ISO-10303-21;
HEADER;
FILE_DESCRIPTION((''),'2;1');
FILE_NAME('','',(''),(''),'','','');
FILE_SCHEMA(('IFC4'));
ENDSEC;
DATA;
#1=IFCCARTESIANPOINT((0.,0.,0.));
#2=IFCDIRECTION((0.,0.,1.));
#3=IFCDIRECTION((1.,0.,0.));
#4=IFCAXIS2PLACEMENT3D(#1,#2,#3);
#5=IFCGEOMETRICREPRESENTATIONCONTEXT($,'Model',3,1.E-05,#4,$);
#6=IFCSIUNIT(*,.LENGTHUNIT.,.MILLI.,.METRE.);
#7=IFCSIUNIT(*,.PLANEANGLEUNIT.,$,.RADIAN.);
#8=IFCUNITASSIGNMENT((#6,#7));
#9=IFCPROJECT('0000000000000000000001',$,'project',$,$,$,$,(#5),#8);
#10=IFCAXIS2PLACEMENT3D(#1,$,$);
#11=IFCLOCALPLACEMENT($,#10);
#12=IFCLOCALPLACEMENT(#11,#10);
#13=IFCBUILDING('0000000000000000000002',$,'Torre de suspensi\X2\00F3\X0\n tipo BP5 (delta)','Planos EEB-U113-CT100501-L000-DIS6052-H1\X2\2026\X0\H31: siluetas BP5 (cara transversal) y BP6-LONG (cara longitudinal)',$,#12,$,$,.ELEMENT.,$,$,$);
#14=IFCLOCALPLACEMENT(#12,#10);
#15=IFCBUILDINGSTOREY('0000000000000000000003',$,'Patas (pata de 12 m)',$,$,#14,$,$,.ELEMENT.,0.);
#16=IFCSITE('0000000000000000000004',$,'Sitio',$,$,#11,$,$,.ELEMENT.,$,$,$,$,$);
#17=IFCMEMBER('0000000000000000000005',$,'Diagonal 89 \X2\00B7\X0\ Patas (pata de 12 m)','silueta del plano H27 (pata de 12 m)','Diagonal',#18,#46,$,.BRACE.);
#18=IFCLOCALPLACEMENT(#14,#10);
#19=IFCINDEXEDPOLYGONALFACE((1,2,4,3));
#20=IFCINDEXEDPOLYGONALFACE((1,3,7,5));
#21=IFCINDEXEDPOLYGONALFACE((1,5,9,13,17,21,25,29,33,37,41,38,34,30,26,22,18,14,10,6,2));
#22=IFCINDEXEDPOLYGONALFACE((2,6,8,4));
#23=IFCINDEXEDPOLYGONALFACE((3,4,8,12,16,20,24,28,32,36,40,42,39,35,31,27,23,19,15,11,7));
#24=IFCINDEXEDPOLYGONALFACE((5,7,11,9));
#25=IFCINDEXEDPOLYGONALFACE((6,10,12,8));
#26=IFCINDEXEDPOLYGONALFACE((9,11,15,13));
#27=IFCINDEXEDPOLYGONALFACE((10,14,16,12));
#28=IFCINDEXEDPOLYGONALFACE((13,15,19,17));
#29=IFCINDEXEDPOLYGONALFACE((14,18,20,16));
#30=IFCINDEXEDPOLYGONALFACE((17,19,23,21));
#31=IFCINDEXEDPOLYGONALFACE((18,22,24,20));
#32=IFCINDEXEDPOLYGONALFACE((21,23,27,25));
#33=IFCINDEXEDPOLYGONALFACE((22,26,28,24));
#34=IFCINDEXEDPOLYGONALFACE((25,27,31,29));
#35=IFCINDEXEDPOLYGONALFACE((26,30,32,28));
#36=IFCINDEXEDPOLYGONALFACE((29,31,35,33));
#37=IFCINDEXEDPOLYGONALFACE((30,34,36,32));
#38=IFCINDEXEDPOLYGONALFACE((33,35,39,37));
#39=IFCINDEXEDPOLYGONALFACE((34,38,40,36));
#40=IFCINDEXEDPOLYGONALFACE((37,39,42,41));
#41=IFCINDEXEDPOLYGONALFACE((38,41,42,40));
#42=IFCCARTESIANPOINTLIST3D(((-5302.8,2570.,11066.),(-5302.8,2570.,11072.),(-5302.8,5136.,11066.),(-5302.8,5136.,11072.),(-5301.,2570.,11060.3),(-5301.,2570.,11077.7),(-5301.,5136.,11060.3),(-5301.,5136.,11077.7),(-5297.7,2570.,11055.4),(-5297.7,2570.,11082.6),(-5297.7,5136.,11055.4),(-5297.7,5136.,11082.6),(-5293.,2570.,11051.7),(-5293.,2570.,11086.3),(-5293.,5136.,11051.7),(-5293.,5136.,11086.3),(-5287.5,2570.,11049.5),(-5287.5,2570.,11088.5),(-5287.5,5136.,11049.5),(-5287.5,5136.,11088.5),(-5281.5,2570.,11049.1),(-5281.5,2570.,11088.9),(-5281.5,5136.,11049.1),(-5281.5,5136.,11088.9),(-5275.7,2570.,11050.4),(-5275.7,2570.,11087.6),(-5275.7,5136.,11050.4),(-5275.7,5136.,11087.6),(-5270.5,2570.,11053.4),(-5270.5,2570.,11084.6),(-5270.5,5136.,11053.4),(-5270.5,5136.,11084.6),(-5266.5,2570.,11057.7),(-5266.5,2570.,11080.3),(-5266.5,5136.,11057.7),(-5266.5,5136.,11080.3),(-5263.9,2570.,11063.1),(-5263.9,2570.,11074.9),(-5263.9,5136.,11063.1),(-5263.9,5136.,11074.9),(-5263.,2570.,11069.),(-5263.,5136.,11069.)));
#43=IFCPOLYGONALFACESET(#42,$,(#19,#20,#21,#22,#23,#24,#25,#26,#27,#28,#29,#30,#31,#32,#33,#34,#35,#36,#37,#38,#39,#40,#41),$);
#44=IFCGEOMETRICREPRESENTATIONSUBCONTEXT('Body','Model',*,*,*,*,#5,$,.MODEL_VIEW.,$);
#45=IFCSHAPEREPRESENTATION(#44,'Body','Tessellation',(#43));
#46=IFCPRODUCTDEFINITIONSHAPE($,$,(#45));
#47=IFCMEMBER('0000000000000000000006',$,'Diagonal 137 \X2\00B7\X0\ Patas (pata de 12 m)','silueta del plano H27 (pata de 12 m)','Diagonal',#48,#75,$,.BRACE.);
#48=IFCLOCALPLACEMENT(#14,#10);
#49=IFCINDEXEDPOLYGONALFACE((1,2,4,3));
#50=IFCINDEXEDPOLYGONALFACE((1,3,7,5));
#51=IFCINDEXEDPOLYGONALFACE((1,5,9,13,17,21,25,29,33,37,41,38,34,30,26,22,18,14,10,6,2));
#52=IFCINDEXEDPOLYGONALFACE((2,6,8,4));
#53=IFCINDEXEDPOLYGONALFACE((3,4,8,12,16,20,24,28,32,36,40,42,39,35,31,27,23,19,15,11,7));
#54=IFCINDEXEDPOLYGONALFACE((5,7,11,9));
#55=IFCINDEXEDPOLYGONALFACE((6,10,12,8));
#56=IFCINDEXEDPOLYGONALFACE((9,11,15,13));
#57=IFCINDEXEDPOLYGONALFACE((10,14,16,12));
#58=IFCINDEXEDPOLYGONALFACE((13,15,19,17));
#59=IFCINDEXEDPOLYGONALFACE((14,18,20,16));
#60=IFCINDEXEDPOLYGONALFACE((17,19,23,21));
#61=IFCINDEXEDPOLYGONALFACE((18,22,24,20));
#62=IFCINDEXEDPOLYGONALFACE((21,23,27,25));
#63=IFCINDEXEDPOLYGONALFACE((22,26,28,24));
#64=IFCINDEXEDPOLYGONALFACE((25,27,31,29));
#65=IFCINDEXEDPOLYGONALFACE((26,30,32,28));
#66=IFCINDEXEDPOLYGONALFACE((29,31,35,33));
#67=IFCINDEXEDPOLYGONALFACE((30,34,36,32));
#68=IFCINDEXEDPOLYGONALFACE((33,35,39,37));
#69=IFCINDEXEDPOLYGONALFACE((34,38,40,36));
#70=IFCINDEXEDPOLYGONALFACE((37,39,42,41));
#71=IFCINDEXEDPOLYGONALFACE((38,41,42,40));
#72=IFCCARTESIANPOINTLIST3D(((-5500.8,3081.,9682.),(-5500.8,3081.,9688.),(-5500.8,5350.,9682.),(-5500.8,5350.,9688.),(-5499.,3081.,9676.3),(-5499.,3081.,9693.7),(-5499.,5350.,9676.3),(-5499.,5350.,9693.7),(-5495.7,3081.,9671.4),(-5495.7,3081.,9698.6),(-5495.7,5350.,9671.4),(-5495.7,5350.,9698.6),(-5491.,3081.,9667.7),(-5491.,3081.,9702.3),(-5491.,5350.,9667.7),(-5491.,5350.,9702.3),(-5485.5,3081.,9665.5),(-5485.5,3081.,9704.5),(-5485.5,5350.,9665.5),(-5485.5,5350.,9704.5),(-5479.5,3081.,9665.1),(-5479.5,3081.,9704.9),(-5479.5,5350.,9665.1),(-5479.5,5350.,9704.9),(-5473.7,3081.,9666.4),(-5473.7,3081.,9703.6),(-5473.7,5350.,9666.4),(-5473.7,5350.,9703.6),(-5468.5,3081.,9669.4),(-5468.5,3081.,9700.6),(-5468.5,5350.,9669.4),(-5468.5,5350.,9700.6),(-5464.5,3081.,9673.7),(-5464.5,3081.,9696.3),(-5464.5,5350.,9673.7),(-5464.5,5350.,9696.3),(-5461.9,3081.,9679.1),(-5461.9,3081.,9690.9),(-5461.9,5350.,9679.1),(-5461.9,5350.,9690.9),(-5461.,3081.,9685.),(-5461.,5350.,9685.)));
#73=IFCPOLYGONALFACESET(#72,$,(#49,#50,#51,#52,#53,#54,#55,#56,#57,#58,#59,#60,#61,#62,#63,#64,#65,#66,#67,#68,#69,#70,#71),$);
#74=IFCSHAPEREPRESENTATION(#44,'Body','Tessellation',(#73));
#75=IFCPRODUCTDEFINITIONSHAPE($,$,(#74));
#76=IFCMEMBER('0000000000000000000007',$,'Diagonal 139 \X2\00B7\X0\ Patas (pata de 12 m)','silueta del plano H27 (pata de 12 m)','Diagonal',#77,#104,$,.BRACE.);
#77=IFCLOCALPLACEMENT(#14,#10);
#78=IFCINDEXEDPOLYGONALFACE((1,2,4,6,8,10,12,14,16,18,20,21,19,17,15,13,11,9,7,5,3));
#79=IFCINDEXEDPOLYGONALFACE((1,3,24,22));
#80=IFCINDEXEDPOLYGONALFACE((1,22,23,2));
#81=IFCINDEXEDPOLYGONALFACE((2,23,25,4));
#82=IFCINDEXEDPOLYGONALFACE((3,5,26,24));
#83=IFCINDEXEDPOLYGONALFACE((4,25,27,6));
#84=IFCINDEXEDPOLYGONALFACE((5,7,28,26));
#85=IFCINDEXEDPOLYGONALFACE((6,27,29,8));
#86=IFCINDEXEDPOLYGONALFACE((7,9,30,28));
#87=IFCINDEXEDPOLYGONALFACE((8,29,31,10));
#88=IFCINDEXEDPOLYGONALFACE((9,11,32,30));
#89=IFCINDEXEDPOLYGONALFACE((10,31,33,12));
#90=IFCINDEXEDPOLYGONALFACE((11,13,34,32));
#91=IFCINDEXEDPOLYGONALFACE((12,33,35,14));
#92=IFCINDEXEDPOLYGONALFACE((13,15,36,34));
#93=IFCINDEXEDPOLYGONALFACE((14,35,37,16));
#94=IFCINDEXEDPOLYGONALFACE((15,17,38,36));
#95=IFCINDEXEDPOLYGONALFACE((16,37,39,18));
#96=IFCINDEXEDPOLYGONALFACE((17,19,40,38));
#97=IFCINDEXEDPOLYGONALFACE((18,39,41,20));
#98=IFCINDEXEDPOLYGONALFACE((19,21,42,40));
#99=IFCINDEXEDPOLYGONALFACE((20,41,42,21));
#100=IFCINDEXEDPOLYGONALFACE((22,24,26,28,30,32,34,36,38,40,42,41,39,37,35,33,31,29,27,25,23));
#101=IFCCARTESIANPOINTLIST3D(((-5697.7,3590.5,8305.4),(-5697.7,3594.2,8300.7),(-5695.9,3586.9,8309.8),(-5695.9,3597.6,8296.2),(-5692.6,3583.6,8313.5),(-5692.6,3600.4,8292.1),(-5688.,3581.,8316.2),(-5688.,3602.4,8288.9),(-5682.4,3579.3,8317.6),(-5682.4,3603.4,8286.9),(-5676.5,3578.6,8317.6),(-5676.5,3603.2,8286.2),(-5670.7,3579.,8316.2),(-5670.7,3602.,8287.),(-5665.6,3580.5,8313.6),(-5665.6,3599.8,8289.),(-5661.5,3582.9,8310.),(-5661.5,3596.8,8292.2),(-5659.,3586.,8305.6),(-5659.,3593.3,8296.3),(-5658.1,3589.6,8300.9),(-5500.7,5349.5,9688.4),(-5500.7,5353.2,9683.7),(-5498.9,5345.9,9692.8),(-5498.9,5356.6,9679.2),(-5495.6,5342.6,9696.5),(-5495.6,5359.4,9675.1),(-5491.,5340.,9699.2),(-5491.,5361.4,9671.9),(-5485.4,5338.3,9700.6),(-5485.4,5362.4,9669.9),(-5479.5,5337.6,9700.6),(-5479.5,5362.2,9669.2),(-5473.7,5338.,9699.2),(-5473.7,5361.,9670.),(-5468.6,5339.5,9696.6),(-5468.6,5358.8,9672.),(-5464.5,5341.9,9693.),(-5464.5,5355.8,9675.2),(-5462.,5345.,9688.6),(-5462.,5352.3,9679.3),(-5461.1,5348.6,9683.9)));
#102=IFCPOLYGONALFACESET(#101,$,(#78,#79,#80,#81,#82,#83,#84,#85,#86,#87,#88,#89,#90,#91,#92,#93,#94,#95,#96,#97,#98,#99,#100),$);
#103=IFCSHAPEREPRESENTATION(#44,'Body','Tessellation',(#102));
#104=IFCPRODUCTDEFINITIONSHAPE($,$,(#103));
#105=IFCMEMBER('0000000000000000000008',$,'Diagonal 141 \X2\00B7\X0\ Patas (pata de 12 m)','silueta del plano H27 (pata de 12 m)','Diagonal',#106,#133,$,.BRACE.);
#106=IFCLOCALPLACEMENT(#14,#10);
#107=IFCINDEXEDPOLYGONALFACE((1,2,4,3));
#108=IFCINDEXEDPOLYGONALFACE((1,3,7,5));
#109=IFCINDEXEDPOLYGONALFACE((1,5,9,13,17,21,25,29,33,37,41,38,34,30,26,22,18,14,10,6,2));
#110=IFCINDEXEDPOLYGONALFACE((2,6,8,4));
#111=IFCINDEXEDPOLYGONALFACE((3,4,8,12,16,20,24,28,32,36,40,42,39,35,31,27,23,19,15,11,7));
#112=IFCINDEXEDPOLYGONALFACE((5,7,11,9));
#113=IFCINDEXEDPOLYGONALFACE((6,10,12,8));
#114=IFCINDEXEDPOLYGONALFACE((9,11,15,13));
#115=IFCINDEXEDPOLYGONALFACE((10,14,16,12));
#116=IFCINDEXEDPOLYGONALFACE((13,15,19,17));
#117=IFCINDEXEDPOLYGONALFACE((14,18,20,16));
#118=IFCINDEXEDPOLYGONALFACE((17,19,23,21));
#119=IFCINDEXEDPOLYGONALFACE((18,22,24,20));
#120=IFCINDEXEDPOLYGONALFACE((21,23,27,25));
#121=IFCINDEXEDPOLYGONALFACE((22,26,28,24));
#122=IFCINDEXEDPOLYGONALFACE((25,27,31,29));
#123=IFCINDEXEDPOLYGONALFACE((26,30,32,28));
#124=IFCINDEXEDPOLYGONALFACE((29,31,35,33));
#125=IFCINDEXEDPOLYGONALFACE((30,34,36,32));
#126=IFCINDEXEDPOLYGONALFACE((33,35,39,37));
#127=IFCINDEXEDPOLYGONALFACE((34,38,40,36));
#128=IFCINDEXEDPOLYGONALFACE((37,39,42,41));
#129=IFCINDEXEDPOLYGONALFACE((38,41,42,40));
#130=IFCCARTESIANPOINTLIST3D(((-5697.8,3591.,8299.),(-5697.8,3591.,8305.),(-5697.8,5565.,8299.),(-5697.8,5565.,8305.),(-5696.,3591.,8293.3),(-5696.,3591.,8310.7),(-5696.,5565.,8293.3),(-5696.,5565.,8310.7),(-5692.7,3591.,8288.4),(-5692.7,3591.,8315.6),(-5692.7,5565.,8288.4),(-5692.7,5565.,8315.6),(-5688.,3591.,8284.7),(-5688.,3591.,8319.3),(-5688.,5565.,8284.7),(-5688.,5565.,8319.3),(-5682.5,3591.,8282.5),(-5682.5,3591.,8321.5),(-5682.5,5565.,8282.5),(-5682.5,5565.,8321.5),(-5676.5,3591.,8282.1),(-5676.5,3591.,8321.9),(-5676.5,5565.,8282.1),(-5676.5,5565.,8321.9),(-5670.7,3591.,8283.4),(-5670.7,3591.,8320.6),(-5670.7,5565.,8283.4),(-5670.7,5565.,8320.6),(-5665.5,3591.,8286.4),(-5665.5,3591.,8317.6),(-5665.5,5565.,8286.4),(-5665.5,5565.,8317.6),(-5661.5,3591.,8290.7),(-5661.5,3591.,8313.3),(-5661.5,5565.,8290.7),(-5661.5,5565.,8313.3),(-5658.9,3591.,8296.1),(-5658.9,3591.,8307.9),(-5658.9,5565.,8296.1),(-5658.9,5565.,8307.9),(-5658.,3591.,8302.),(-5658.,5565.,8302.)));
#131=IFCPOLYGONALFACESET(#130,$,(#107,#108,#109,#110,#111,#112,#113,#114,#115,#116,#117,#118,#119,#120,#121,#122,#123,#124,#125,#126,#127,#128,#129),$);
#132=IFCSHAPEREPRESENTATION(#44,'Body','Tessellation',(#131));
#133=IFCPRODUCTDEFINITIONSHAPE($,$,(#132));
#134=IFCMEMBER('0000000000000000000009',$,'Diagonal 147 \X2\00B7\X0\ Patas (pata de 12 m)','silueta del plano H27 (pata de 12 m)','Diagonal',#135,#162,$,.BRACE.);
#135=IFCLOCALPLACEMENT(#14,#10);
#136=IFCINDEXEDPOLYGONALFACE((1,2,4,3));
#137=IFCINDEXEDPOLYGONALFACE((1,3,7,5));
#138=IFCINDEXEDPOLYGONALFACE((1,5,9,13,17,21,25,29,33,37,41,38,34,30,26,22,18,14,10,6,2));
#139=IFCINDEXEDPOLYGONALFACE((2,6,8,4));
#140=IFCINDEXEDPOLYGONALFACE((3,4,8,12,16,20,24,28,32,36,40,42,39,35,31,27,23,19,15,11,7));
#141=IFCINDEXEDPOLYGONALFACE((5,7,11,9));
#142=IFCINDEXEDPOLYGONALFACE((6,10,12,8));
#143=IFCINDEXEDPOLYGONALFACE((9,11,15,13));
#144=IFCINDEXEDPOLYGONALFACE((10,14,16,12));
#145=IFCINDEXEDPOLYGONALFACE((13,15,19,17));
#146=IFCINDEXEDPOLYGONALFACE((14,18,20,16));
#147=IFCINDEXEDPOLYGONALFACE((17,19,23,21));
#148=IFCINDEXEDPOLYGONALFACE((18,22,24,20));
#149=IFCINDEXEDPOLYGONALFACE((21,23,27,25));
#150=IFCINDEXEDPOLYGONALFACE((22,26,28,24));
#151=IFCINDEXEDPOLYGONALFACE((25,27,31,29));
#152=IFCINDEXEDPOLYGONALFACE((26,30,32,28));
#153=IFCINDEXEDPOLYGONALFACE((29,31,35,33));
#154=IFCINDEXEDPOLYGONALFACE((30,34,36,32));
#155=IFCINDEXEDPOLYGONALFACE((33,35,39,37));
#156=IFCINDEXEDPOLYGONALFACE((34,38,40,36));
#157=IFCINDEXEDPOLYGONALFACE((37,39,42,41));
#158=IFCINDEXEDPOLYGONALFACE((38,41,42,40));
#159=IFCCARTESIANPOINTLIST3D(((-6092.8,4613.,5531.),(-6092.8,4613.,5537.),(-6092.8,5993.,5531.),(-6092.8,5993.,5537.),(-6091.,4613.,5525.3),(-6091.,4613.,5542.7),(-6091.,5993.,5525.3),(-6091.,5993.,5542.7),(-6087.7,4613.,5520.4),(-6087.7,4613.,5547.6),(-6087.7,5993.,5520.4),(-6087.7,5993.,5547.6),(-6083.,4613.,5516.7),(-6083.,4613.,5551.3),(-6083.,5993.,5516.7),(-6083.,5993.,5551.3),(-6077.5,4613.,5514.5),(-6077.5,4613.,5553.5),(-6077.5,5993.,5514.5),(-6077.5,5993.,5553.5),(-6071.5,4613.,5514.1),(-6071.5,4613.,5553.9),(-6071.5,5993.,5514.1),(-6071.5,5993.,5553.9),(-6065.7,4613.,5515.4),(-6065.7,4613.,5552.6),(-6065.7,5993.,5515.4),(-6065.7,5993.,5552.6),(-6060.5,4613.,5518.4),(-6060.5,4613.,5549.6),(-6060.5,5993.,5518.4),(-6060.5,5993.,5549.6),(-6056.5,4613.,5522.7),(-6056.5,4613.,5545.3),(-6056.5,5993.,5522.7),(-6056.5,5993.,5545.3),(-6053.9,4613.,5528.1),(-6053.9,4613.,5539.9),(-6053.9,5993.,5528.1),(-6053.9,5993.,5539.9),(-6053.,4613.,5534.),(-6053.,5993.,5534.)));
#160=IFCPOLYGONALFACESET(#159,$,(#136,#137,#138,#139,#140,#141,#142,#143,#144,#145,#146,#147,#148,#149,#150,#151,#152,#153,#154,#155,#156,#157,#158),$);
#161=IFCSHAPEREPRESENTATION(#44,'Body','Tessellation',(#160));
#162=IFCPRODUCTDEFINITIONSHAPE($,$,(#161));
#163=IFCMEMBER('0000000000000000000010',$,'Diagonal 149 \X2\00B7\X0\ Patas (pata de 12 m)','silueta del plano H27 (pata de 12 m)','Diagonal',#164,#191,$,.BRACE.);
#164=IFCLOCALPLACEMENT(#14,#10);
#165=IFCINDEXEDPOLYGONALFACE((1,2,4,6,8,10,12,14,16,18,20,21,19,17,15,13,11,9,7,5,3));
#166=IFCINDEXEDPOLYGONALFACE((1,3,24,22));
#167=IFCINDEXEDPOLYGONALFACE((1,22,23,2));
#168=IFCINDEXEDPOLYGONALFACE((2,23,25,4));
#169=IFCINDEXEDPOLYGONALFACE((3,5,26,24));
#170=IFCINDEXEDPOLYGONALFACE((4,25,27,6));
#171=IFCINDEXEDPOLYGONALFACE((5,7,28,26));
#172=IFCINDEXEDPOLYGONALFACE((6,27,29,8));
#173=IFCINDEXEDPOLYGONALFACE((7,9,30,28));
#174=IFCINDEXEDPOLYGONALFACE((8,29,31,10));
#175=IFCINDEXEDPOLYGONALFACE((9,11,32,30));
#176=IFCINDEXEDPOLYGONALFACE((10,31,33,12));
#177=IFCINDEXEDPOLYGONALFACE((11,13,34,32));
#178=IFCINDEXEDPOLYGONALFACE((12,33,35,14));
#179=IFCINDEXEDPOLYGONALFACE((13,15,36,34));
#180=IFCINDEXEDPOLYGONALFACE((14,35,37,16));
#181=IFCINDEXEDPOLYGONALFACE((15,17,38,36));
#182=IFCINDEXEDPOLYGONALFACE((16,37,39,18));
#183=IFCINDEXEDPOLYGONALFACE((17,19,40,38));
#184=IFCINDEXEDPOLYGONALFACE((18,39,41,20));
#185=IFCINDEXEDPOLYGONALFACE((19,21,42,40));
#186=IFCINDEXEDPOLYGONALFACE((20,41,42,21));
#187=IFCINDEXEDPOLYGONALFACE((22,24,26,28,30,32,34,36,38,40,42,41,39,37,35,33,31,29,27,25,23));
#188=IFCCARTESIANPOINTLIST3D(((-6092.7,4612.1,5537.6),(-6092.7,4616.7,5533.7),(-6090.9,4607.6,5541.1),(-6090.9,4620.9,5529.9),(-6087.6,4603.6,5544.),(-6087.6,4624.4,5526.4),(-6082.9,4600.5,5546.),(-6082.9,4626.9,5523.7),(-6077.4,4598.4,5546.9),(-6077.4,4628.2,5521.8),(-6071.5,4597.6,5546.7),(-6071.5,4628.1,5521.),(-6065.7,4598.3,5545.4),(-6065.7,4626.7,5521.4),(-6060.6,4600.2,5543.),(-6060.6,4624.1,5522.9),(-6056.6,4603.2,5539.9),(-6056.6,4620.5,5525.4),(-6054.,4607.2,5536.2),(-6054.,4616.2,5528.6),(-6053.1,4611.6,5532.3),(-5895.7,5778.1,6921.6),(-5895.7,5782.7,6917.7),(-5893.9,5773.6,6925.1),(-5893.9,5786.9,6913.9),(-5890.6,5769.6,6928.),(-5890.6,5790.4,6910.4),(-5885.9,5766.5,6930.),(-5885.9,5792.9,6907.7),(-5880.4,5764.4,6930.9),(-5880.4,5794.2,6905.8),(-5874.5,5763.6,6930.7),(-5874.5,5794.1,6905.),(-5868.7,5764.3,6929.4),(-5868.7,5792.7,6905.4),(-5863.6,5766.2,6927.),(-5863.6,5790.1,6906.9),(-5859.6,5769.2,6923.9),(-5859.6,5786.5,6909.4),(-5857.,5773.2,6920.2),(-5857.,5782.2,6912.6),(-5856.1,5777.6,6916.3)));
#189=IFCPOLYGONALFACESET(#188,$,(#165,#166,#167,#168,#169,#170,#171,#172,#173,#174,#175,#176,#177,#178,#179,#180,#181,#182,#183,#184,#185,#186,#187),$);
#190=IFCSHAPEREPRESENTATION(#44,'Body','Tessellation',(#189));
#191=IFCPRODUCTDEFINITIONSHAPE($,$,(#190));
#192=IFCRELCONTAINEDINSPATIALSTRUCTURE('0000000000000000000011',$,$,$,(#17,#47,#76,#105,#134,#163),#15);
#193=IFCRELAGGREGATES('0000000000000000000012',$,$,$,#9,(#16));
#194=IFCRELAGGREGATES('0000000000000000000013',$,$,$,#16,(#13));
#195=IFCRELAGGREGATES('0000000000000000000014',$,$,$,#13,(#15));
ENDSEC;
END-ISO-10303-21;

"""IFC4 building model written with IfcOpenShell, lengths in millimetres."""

from ifc_helpers import new_model, si_unit, frame, origin, origin_with_axes, place, context, subcontext, project, spatial, circle, extrude, element, save


model = new_model("IFC4")

# Units and contexts
model_context = context("Model", 3, precision=1e-05, world=origin_with_axes())
body_context = subcontext(model_context, "Body", "Model", "MODEL_VIEW")
ifc_project = project(units=[si_unit("LENGTHUNIT", "METRE", prefix="MILLI"), si_unit("PLANEANGLEUNIT", "RADIAN")], contexts=[model_context])

# Site, building, storey
site_placement = place(None, origin())
site = spatial("IfcSite", under=ifc_project, at=site_placement, Name="Sitio", CompositionType="ELEMENT")
building_placement = place(site_placement, origin())
building = spatial("IfcBuilding", under=site, at=building_placement, Name="Torre de suspensión tipo BP5 (delta)", Description="Planos EEB-U113-CT100501-L000-DIS6052-H1…H31: siluetas BP5 (cara transversal) y BP6-LONG (cara longitudinal)", CompositionType="ELEMENT")
storey_placement = place(building_placement, origin())
storey = spatial("IfcBuildingStorey", under=building, at=storey_placement, Name="Patas (pata de 12 m)", CompositionType="ELEMENT", Elevation=0.0)

# Members
member_1_placement = place(storey_placement, frame((-5283.0, 5136.0, 11069.0), z_axis=(0.0, -1.0, 0.0), x_axis=(1.0, 0.0, 0.0)))
element("IfcMember", 1, at=member_1_placement, inside=storey, Name="Diagonal 89 · Patas (pata de 12 m)", Description="silueta del plano H27 (pata de 12 m)", ObjectType="Diagonal", PredefinedType="BRACE", context=body_context, shape_type="SweptSolid", body=[
    extrude(circle(Radius=20.0), None, (0.0, 0.0, 1.0), 2566.0),
])
member_2_placement = place(storey_placement, frame((-5481.0, 3081.0, 9685.0), z_axis=(0.0, 1.0, 0.0), x_axis=(1.0, 0.0, 0.0)))
element("IfcMember", 2, at=member_2_placement, inside=storey, Name="Diagonal 137 · Patas (pata de 12 m)", Description="silueta del plano H27 (pata de 12 m)", ObjectType="Diagonal", PredefinedType="BRACE", context=body_context, shape_type="SweptSolid", body=[
    extrude(circle(Radius=20.0), None, (0.0, 0.0, 1.0), 2269.0),
])
member_3_placement = place(storey_placement, frame((-5678.0, 3591.0, 8302.0), z_axis=(0.087702, 0.783088, 0.615696), x_axis=(0.996147, -0.068944, -0.054207)))
element("IfcMember", 3, at=member_3_placement, inside=storey, Name="Diagonal 139 · Patas (pata de 12 m)", Description="silueta del plano H27 (pata de 12 m)", ObjectType="Diagonal", PredefinedType="BRACE", context=body_context, shape_type="SweptSolid", body=[
    extrude(circle(Radius=20.0), None, (0.0, 0.0, 1.0), 2246.2),
])
member_4_placement = place(storey_placement, frame((-5678.0, 5565.0, 8302.0), z_axis=(0.0, -1.0, 0.0), x_axis=(1.0, 0.0, 0.0)))
element("IfcMember", 4, at=member_4_placement, inside=storey, Name="Diagonal 141 · Patas (pata de 12 m)", Description="silueta del plano H27 (pata de 12 m)", ObjectType="Diagonal", PredefinedType="BRACE", context=body_context, shape_type="SweptSolid", body=[
    extrude(circle(Radius=20.0), None, (0.0, 0.0, 1.0), 1974.0),
])
member_5_placement = place(storey_placement, frame((-6073.0, 5993.0, 5534.0), z_axis=(0.0, -1.0, 0.0), x_axis=(1.0, 0.0, 0.0)))
element("IfcMember", 5, at=member_5_placement, inside=storey, Name="Diagonal 147 · Patas (pata de 12 m)", Description="silueta del plano H27 (pata de 12 m)", ObjectType="Diagonal", PredefinedType="BRACE", context=body_context, shape_type="SweptSolid", body=[
    extrude(circle(Radius=20.0), None, (0.0, 0.0, 1.0), 1380.0),
])
member_6_placement = place(storey_placement, frame((-6073.0, 4613.0, 5534.0), z_axis=(0.108219, 0.640522, 0.760277), x_axis=(0.994127, -0.069726, -0.082762)))
element("IfcMember", 6, at=member_6_placement, inside=storey, Name="Diagonal 149 · Patas (pata de 12 m)", Description="silueta del plano H27 (pata de 12 m)", ObjectType="Diagonal", PredefinedType="BRACE", context=body_context, shape_type="SweptSolid", body=[
    extrude(circle(Radius=20.0), None, (0.0, 0.0, 1.0), 1820.4),
])

save(model, "model.ifc")
